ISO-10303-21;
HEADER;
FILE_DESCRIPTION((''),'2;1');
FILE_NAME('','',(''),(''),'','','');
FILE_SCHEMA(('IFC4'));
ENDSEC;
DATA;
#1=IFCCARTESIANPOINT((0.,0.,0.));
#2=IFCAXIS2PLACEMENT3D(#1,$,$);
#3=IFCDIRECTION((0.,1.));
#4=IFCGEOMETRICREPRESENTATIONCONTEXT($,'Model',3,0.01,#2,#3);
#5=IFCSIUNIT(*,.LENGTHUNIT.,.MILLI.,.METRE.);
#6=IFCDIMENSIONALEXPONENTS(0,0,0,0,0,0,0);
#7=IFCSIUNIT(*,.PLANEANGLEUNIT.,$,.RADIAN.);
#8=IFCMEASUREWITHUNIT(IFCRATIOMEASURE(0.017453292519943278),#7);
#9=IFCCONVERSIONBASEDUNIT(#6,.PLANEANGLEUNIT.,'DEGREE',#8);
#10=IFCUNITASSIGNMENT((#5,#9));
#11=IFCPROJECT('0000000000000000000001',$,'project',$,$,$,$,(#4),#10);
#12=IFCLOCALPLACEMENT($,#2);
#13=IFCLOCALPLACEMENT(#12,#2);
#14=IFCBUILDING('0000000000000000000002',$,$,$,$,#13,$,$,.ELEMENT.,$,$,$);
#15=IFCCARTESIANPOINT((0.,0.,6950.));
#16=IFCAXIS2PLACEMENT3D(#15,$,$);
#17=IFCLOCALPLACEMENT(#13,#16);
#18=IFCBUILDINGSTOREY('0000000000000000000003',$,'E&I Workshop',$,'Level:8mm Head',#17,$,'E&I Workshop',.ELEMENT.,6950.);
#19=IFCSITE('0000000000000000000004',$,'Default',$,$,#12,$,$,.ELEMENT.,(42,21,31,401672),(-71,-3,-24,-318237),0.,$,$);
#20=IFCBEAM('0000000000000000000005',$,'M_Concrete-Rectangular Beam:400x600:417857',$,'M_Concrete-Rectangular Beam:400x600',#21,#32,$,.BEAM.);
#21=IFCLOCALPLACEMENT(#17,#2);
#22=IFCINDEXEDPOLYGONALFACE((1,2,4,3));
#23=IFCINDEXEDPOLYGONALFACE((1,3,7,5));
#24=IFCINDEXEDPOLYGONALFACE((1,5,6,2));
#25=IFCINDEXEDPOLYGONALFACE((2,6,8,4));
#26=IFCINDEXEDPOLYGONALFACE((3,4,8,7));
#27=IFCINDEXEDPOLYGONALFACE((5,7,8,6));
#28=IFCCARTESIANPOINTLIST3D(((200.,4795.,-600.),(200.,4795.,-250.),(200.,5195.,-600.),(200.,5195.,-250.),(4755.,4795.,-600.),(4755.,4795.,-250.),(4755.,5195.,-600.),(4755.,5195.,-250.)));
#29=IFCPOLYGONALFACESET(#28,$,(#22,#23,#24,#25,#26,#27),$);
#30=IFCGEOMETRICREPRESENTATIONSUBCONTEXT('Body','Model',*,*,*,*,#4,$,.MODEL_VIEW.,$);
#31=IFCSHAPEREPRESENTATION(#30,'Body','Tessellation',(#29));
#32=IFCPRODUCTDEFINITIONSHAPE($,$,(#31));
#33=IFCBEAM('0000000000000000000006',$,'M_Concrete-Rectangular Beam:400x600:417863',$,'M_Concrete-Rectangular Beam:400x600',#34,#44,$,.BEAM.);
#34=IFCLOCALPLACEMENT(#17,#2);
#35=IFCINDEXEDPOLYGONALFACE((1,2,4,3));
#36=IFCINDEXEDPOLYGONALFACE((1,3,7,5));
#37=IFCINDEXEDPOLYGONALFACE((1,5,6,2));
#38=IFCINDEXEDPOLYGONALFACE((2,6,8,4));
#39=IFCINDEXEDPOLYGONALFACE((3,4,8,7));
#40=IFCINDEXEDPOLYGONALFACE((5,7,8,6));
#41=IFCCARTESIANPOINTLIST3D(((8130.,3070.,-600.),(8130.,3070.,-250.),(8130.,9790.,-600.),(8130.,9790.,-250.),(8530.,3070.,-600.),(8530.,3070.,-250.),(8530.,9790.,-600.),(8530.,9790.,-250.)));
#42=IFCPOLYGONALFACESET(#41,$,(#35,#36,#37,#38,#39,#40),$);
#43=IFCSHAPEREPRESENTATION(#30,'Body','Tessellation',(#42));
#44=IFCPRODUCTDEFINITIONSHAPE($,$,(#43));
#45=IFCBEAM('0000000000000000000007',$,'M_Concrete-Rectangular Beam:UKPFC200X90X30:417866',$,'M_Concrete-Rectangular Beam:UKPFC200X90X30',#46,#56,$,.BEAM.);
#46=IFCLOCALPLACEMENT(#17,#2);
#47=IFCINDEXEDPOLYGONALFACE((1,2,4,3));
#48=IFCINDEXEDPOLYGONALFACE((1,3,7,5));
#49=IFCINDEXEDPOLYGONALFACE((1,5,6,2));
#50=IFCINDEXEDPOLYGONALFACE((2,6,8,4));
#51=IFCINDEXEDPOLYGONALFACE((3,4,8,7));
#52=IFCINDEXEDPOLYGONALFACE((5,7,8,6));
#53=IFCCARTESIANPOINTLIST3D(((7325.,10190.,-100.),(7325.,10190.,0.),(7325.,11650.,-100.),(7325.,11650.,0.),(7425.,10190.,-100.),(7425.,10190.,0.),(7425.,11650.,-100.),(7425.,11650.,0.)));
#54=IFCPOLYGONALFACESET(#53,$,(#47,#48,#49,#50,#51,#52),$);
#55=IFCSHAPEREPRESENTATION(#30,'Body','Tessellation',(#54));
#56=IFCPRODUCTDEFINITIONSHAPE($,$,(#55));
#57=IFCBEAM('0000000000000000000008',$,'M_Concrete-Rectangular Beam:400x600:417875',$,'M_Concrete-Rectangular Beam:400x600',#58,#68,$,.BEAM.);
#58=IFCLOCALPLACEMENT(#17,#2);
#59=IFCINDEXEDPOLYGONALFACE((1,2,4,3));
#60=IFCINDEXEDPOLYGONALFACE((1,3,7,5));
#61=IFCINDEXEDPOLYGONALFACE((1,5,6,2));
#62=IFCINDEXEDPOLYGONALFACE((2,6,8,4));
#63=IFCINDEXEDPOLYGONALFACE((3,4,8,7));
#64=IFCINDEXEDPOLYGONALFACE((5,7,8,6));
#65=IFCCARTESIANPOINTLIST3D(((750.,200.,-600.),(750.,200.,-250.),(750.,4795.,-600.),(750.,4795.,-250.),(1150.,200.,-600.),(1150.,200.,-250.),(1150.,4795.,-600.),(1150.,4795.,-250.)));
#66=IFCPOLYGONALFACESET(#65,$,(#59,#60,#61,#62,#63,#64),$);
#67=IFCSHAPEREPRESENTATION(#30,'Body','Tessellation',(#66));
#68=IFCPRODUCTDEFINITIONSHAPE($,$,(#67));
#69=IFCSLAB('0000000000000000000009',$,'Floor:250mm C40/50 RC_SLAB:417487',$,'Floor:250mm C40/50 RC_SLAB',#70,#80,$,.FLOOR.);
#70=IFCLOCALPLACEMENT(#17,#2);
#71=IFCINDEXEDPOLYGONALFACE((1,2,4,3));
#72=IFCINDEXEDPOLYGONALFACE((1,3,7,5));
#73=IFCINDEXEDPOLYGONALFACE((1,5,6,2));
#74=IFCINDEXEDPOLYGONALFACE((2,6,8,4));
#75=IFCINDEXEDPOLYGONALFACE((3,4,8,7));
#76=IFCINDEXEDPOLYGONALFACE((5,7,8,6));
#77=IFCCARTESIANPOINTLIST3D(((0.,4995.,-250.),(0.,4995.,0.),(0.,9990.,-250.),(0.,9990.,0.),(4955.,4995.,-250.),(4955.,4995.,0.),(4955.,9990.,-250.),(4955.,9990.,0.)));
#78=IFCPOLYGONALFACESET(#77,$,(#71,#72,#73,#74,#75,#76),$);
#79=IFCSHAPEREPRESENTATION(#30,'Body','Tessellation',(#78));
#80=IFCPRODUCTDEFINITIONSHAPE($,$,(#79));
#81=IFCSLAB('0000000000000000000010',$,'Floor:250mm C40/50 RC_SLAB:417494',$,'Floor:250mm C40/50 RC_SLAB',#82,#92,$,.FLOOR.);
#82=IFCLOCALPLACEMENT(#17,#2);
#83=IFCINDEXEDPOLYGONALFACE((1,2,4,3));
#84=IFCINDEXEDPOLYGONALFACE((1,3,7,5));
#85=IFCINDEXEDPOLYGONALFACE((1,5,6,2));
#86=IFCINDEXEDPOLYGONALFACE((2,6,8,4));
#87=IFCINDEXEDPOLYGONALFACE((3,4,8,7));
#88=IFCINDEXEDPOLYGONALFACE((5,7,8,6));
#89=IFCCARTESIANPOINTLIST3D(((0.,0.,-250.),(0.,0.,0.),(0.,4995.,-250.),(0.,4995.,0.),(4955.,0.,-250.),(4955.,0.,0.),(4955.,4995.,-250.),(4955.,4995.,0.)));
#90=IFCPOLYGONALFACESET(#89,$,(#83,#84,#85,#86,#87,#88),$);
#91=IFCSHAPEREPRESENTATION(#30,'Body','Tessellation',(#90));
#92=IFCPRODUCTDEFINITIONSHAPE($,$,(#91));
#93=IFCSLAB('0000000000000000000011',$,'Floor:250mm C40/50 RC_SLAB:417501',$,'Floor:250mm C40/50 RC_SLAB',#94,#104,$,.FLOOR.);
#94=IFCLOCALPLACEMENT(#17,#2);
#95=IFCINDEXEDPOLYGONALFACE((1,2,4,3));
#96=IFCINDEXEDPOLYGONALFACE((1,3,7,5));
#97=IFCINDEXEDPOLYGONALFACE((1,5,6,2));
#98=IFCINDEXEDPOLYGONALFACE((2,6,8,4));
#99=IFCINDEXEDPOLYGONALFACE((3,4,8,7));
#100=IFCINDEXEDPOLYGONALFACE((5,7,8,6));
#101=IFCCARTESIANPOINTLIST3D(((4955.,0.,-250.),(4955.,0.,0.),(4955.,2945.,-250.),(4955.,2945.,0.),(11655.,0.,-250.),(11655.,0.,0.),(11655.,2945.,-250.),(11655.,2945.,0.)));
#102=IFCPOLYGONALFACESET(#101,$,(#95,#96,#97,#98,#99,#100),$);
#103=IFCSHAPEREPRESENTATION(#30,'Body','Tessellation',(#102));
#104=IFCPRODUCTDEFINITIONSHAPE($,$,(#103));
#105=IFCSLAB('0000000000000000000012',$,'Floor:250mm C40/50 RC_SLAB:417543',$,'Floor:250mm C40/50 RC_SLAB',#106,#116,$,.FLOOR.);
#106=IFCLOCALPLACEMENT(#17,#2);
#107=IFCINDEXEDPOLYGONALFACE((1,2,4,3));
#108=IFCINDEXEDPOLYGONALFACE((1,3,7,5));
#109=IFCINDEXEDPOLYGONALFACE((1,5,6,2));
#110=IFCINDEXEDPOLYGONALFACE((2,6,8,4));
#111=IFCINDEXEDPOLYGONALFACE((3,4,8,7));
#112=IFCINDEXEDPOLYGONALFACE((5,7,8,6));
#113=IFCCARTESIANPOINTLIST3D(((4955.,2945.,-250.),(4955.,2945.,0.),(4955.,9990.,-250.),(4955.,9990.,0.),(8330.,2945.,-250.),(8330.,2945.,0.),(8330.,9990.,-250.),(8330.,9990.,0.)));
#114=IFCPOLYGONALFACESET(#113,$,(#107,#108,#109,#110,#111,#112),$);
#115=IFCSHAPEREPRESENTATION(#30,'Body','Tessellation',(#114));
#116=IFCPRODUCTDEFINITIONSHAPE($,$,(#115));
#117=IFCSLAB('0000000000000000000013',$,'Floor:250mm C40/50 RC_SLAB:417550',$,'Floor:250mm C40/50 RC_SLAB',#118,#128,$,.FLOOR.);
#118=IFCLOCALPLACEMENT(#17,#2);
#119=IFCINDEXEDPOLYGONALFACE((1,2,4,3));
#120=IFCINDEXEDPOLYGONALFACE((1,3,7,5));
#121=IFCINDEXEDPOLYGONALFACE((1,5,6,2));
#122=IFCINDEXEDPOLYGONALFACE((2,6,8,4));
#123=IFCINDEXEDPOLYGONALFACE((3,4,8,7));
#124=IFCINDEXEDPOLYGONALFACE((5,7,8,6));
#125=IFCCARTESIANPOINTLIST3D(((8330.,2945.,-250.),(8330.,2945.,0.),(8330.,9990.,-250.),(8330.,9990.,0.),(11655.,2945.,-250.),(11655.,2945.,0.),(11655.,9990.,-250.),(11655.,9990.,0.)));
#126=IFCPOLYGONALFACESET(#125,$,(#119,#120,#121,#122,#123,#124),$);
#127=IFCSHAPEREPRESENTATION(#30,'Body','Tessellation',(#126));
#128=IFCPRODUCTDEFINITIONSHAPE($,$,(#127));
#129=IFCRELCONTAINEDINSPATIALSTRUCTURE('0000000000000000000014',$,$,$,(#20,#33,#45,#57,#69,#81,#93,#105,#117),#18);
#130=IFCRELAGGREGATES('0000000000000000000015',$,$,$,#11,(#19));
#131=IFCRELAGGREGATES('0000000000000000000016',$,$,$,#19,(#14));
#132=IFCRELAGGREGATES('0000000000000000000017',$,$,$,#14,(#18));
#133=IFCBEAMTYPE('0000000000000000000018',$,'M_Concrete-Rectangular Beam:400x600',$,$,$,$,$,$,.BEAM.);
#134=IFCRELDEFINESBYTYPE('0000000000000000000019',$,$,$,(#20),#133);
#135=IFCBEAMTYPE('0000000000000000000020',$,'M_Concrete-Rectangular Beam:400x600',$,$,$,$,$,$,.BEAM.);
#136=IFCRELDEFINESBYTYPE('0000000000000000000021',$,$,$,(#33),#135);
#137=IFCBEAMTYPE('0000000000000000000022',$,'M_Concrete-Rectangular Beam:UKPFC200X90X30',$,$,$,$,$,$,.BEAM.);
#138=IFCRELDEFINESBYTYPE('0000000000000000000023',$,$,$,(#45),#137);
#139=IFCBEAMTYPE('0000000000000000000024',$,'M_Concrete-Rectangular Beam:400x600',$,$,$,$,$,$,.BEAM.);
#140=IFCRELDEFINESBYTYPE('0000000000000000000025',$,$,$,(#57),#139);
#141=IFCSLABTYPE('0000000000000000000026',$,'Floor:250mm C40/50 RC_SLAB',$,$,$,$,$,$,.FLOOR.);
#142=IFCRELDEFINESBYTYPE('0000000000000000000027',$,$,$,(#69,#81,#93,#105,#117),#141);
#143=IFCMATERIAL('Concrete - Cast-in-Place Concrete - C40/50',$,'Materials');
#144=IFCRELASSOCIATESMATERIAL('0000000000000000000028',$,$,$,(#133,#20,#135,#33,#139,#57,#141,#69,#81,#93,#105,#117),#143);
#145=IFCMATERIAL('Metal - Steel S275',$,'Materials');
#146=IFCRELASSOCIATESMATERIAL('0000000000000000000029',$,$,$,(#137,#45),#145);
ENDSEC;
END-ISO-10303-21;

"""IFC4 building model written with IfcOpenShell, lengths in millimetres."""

from ifc_helpers import new_model, entity, si_unit, converted_unit, direction, frame, origin, place, context, subcontext, project, spatial, indexed_curve, outline, extrude, source, transform, mapped, material, type_object, type_shapes, element, save


model = new_model("IFC4")

# Units and contexts
model_context = context("Model", 3, precision=0.01, world=origin(), true_north=direction((0.0, 1.0)))
body_context = subcontext(model_context, "Body", "Model", "MODEL_VIEW")
ifc_project = project(units=[si_unit("LENGTHUNIT", "METRE", prefix="MILLI"), converted_unit("PLANEANGLEUNIT", "DEGREE", entity("IfcRatioMeasure", 0.017453292519943278), si_unit("PLANEANGLEUNIT", "RADIAN"), dimensions=[0, 0, 0, 0, 0, 0, 0])], contexts=[model_context])

# Site, building, storey
site_placement = place(None, origin())
site = spatial("IfcSite", under=ifc_project, at=site_placement, Name="Default", CompositionType="ELEMENT", RefLatitude=(42, 21, 31, 401672), RefLongitude=(-71, -3, -24, -318237), RefElevation=0.0)
building_placement = place(site_placement, origin())
building = spatial("IfcBuilding", under=site, at=building_placement, CompositionType="ELEMENT")
storey_placement = place(building_placement, frame((0.0, 0.0, 6950.0)))
storey = spatial("IfcBuildingStorey", under=building, at=storey_placement, Name="E&I Workshop", ObjectType="Level:8mm Head", LongName="E&I Workshop", CompositionType="ELEMENT", Elevation=6950.0)

# Beams
ifc_material_1 = material(Name="Concrete - Cast-in-Place Concrete - C40/50", Category="Materials")
beam_type_1 = type_object("IfcBeamType", Name="M_Concrete-Rectangular Beam:400x600", PredefinedType="BEAM", material=ifc_material_1)
shared_shape_1 = source(origin(), body_context, "Body", "SweptSolid", [
    extrude(outline(indexed_curve([(-175.0, -200.0), (175.0, -200.0), (175.0, 200.0), (-175.0, 200.0), (-175.0, -200.0)], self_intersect=False)), frame((200.0, 4995.0, 6525.0), z_axis=(1.0, 0.0, 0.0), x_axis=(0.0, 0.0, -1.0)), (0.0, 0.0, 1.0), 4555.0),
])
type_shapes(beam_type_1, [shared_shape_1])
beam_1_placement = place(storey_placement, frame((0.0, 0.0, -6950.0)))
element("IfcBeam", 1, at=beam_1_placement, inside=storey, type_object=beam_type_1, material=ifc_material_1, Name="M_Concrete-Rectangular Beam:400x600:417857", ObjectType="M_Concrete-Rectangular Beam:400x600", PredefinedType="BEAM", context=body_context, shape_type="MappedRepresentation", body=[
    mapped(shared_shape_1, transform((0.0, 0.0, 0.0), scale=1.0)),
])
beam_type_2 = type_object("IfcBeamType", Name="M_Concrete-Rectangular Beam:400x600", PredefinedType="BEAM", material=ifc_material_1)
shared_shape_2 = source(origin(), body_context, "Body", "SweptSolid", [
    extrude(outline(indexed_curve([(-200.0, -175.0), (200.0, -175.0), (200.0, 175.0), (-200.0, 175.0), (-200.0, -175.0)], self_intersect=False)), frame((8330.0, 3070.0, 6525.0), z_axis=(0.0, 1.0, 0.0), x_axis=(-1.0, 0.0, 0.0)), (0.0, 0.0, 1.0), 6720.0),
])
type_shapes(beam_type_2, [shared_shape_2])
beam_2_placement = place(storey_placement, frame((0.0, 0.0, -6950.0)))
element("IfcBeam", 2, at=beam_2_placement, inside=storey, type_object=beam_type_2, material=ifc_material_1, Name="M_Concrete-Rectangular Beam:400x600:417863", ObjectType="M_Concrete-Rectangular Beam:400x600", PredefinedType="BEAM", context=body_context, shape_type="MappedRepresentation", body=[
    mapped(shared_shape_2, transform((0.0, 0.0, 0.0), scale=1.0)),
])
ifc_material_2 = material(Name="Metal - Steel S275", Category="Materials")
beam_type_3 = type_object("IfcBeamType", Name="M_Concrete-Rectangular Beam:UKPFC200X90X30", PredefinedType="BEAM", material=ifc_material_2)
shared_shape_3 = source(origin(), body_context, "Body", "SweptSolid", [
    extrude(outline(indexed_curve([(-50.0, -50.0), (50.0, -50.0), (50.0, 50.0), (-50.0, 50.0), (-50.0, -50.0)], self_intersect=False)), frame((7375.0, 10190.0, 6900.0), z_axis=(0.0, 1.0, 0.0), x_axis=(-1.0, 0.0, 0.0)), (0.0, 0.0, 1.0), 1460.0),
])
type_shapes(beam_type_3, [shared_shape_3])
beam_3_placement = place(storey_placement, frame((0.0, 0.0, -6950.0)))
element("IfcBeam", 3, at=beam_3_placement, inside=storey, type_object=beam_type_3, material=ifc_material_2, Name="M_Concrete-Rectangular Beam:UKPFC200X90X30:417866", ObjectType="M_Concrete-Rectangular Beam:UKPFC200X90X30", PredefinedType="BEAM", context=body_context, shape_type="MappedRepresentation", body=[
    mapped(shared_shape_3, transform((0.0, 0.0, 0.0), scale=1.0)),
])
beam_type_4 = type_object("IfcBeamType", Name="M_Concrete-Rectangular Beam:400x600", PredefinedType="BEAM", material=ifc_material_1)
shared_shape_4 = source(origin(), body_context, "Body", "SweptSolid", [
    extrude(outline(indexed_curve([(-200.0, -175.0), (200.0, -175.0), (200.0, 175.0), (-200.0, 175.0), (-200.0, -175.0)], self_intersect=False)), frame((950.0, 200.0, 6525.0), z_axis=(0.0, 1.0, 0.0), x_axis=(-1.0, 0.0, 0.0)), (0.0, 0.0, 1.0), 4595.0),
])
type_shapes(beam_type_4, [shared_shape_4])
beam_4_placement = place(storey_placement, frame((0.0, 0.0, -6950.0)))
element("IfcBeam", 4, at=beam_4_placement, inside=storey, type_object=beam_type_4, material=ifc_material_1, Name="M_Concrete-Rectangular Beam:400x600:417875", ObjectType="M_Concrete-Rectangular Beam:400x600", PredefinedType="BEAM", context=body_context, shape_type="MappedRepresentation", body=[
    mapped(shared_shape_4, transform((0.0, 0.0, 0.0), scale=1.0)),
])

# Slabs
slab_type = type_object("IfcSlabType", Name="Floor:250mm C40/50 RC_SLAB", PredefinedType="FLOOR", material=ifc_material_1)
slab_1_placement = place(storey_placement, origin())
element("IfcSlab", 5, at=slab_1_placement, inside=storey, type_object=slab_type, material=ifc_material_1, Name="Floor:250mm C40/50 RC_SLAB:417487", ObjectType="Floor:250mm C40/50 RC_SLAB", PredefinedType="FLOOR", context=body_context, shape_type="SweptSolid", body=[
    extrude(outline(indexed_curve([(-2497.5, -2477.5), (2497.5, -2477.5), (2497.5, 2477.5), (-2497.5, 2477.5), (-2497.5, -2477.5)], self_intersect=False)), frame((2477.5, 7492.5, 0.0), z_axis=(0.0, 0.0, -1.0), x_axis=(0.0, 1.0, 0.0)), (0.0, 0.0, 1.0), 250.0),
])
slab_2_placement = place(storey_placement, origin())
element("IfcSlab", 6, at=slab_2_placement, inside=storey, type_object=slab_type, material=ifc_material_1, Name="Floor:250mm C40/50 RC_SLAB:417494", ObjectType="Floor:250mm C40/50 RC_SLAB", PredefinedType="FLOOR", context=body_context, shape_type="SweptSolid", body=[
    extrude(outline(indexed_curve([(-2497.5, -2477.5), (2497.5, -2477.5), (2497.5, 2477.5), (-2497.5, 2477.5), (-2497.5, -2477.5)], self_intersect=False)), frame((2477.5, 2497.5, 0.0), z_axis=(0.0, 0.0, -1.0), x_axis=(0.0, 1.0, 0.0)), (0.0, 0.0, 1.0), 250.0),
])
slab_3_placement = place(storey_placement, origin())
element("IfcSlab", 7, at=slab_3_placement, inside=storey, type_object=slab_type, material=ifc_material_1, Name="Floor:250mm C40/50 RC_SLAB:417501", ObjectType="Floor:250mm C40/50 RC_SLAB", PredefinedType="FLOOR", context=body_context, shape_type="SweptSolid", body=[
    extrude(outline(indexed_curve([(-1472.5, -3350.0), (1472.5, -3350.0), (1472.5, 3350.0), (-1472.5, 3350.0), (-1472.5, -3350.0)], self_intersect=False)), frame((8305.0, 1472.5, 0.0), z_axis=(0.0, 0.0, -1.0), x_axis=(0.0, 1.0, 0.0)), (0.0, 0.0, 1.0), 250.0),
])
slab_4_placement = place(storey_placement, origin())
element("IfcSlab", 8, at=slab_4_placement, inside=storey, type_object=slab_type, material=ifc_material_1, Name="Floor:250mm C40/50 RC_SLAB:417543", ObjectType="Floor:250mm C40/50 RC_SLAB", PredefinedType="FLOOR", context=body_context, shape_type="SweptSolid", body=[
    extrude(outline(indexed_curve([(-3522.5, -1687.5), (3522.5, -1687.5), (3522.5, 1687.5), (-3522.5, 1687.5), (-3522.5, -1687.5)], self_intersect=False)), frame((6642.5, 6467.5, 0.0), z_axis=(0.0, 0.0, -1.0), x_axis=(0.0, 1.0, 0.0)), (0.0, 0.0, 1.0), 250.0),
])
slab_5_placement = place(storey_placement, origin())
element("IfcSlab", 9, at=slab_5_placement, inside=storey, type_object=slab_type, material=ifc_material_1, Name="Floor:250mm C40/50 RC_SLAB:417550", ObjectType="Floor:250mm C40/50 RC_SLAB", PredefinedType="FLOOR", context=body_context, shape_type="SweptSolid", body=[
    extrude(outline(indexed_curve([(-3522.5, -1662.5), (3522.5, -1662.5), (3522.5, 1662.5), (-3522.5, 1662.5), (-3522.5, -1662.5)], self_intersect=False)), frame((9992.5, 6467.5, 0.0), z_axis=(0.0, 0.0, -1.0), x_axis=(0.0, 1.0, 0.0)), (0.0, 0.0, 1.0), 250.0),
])

save(model, "model.ifc")
